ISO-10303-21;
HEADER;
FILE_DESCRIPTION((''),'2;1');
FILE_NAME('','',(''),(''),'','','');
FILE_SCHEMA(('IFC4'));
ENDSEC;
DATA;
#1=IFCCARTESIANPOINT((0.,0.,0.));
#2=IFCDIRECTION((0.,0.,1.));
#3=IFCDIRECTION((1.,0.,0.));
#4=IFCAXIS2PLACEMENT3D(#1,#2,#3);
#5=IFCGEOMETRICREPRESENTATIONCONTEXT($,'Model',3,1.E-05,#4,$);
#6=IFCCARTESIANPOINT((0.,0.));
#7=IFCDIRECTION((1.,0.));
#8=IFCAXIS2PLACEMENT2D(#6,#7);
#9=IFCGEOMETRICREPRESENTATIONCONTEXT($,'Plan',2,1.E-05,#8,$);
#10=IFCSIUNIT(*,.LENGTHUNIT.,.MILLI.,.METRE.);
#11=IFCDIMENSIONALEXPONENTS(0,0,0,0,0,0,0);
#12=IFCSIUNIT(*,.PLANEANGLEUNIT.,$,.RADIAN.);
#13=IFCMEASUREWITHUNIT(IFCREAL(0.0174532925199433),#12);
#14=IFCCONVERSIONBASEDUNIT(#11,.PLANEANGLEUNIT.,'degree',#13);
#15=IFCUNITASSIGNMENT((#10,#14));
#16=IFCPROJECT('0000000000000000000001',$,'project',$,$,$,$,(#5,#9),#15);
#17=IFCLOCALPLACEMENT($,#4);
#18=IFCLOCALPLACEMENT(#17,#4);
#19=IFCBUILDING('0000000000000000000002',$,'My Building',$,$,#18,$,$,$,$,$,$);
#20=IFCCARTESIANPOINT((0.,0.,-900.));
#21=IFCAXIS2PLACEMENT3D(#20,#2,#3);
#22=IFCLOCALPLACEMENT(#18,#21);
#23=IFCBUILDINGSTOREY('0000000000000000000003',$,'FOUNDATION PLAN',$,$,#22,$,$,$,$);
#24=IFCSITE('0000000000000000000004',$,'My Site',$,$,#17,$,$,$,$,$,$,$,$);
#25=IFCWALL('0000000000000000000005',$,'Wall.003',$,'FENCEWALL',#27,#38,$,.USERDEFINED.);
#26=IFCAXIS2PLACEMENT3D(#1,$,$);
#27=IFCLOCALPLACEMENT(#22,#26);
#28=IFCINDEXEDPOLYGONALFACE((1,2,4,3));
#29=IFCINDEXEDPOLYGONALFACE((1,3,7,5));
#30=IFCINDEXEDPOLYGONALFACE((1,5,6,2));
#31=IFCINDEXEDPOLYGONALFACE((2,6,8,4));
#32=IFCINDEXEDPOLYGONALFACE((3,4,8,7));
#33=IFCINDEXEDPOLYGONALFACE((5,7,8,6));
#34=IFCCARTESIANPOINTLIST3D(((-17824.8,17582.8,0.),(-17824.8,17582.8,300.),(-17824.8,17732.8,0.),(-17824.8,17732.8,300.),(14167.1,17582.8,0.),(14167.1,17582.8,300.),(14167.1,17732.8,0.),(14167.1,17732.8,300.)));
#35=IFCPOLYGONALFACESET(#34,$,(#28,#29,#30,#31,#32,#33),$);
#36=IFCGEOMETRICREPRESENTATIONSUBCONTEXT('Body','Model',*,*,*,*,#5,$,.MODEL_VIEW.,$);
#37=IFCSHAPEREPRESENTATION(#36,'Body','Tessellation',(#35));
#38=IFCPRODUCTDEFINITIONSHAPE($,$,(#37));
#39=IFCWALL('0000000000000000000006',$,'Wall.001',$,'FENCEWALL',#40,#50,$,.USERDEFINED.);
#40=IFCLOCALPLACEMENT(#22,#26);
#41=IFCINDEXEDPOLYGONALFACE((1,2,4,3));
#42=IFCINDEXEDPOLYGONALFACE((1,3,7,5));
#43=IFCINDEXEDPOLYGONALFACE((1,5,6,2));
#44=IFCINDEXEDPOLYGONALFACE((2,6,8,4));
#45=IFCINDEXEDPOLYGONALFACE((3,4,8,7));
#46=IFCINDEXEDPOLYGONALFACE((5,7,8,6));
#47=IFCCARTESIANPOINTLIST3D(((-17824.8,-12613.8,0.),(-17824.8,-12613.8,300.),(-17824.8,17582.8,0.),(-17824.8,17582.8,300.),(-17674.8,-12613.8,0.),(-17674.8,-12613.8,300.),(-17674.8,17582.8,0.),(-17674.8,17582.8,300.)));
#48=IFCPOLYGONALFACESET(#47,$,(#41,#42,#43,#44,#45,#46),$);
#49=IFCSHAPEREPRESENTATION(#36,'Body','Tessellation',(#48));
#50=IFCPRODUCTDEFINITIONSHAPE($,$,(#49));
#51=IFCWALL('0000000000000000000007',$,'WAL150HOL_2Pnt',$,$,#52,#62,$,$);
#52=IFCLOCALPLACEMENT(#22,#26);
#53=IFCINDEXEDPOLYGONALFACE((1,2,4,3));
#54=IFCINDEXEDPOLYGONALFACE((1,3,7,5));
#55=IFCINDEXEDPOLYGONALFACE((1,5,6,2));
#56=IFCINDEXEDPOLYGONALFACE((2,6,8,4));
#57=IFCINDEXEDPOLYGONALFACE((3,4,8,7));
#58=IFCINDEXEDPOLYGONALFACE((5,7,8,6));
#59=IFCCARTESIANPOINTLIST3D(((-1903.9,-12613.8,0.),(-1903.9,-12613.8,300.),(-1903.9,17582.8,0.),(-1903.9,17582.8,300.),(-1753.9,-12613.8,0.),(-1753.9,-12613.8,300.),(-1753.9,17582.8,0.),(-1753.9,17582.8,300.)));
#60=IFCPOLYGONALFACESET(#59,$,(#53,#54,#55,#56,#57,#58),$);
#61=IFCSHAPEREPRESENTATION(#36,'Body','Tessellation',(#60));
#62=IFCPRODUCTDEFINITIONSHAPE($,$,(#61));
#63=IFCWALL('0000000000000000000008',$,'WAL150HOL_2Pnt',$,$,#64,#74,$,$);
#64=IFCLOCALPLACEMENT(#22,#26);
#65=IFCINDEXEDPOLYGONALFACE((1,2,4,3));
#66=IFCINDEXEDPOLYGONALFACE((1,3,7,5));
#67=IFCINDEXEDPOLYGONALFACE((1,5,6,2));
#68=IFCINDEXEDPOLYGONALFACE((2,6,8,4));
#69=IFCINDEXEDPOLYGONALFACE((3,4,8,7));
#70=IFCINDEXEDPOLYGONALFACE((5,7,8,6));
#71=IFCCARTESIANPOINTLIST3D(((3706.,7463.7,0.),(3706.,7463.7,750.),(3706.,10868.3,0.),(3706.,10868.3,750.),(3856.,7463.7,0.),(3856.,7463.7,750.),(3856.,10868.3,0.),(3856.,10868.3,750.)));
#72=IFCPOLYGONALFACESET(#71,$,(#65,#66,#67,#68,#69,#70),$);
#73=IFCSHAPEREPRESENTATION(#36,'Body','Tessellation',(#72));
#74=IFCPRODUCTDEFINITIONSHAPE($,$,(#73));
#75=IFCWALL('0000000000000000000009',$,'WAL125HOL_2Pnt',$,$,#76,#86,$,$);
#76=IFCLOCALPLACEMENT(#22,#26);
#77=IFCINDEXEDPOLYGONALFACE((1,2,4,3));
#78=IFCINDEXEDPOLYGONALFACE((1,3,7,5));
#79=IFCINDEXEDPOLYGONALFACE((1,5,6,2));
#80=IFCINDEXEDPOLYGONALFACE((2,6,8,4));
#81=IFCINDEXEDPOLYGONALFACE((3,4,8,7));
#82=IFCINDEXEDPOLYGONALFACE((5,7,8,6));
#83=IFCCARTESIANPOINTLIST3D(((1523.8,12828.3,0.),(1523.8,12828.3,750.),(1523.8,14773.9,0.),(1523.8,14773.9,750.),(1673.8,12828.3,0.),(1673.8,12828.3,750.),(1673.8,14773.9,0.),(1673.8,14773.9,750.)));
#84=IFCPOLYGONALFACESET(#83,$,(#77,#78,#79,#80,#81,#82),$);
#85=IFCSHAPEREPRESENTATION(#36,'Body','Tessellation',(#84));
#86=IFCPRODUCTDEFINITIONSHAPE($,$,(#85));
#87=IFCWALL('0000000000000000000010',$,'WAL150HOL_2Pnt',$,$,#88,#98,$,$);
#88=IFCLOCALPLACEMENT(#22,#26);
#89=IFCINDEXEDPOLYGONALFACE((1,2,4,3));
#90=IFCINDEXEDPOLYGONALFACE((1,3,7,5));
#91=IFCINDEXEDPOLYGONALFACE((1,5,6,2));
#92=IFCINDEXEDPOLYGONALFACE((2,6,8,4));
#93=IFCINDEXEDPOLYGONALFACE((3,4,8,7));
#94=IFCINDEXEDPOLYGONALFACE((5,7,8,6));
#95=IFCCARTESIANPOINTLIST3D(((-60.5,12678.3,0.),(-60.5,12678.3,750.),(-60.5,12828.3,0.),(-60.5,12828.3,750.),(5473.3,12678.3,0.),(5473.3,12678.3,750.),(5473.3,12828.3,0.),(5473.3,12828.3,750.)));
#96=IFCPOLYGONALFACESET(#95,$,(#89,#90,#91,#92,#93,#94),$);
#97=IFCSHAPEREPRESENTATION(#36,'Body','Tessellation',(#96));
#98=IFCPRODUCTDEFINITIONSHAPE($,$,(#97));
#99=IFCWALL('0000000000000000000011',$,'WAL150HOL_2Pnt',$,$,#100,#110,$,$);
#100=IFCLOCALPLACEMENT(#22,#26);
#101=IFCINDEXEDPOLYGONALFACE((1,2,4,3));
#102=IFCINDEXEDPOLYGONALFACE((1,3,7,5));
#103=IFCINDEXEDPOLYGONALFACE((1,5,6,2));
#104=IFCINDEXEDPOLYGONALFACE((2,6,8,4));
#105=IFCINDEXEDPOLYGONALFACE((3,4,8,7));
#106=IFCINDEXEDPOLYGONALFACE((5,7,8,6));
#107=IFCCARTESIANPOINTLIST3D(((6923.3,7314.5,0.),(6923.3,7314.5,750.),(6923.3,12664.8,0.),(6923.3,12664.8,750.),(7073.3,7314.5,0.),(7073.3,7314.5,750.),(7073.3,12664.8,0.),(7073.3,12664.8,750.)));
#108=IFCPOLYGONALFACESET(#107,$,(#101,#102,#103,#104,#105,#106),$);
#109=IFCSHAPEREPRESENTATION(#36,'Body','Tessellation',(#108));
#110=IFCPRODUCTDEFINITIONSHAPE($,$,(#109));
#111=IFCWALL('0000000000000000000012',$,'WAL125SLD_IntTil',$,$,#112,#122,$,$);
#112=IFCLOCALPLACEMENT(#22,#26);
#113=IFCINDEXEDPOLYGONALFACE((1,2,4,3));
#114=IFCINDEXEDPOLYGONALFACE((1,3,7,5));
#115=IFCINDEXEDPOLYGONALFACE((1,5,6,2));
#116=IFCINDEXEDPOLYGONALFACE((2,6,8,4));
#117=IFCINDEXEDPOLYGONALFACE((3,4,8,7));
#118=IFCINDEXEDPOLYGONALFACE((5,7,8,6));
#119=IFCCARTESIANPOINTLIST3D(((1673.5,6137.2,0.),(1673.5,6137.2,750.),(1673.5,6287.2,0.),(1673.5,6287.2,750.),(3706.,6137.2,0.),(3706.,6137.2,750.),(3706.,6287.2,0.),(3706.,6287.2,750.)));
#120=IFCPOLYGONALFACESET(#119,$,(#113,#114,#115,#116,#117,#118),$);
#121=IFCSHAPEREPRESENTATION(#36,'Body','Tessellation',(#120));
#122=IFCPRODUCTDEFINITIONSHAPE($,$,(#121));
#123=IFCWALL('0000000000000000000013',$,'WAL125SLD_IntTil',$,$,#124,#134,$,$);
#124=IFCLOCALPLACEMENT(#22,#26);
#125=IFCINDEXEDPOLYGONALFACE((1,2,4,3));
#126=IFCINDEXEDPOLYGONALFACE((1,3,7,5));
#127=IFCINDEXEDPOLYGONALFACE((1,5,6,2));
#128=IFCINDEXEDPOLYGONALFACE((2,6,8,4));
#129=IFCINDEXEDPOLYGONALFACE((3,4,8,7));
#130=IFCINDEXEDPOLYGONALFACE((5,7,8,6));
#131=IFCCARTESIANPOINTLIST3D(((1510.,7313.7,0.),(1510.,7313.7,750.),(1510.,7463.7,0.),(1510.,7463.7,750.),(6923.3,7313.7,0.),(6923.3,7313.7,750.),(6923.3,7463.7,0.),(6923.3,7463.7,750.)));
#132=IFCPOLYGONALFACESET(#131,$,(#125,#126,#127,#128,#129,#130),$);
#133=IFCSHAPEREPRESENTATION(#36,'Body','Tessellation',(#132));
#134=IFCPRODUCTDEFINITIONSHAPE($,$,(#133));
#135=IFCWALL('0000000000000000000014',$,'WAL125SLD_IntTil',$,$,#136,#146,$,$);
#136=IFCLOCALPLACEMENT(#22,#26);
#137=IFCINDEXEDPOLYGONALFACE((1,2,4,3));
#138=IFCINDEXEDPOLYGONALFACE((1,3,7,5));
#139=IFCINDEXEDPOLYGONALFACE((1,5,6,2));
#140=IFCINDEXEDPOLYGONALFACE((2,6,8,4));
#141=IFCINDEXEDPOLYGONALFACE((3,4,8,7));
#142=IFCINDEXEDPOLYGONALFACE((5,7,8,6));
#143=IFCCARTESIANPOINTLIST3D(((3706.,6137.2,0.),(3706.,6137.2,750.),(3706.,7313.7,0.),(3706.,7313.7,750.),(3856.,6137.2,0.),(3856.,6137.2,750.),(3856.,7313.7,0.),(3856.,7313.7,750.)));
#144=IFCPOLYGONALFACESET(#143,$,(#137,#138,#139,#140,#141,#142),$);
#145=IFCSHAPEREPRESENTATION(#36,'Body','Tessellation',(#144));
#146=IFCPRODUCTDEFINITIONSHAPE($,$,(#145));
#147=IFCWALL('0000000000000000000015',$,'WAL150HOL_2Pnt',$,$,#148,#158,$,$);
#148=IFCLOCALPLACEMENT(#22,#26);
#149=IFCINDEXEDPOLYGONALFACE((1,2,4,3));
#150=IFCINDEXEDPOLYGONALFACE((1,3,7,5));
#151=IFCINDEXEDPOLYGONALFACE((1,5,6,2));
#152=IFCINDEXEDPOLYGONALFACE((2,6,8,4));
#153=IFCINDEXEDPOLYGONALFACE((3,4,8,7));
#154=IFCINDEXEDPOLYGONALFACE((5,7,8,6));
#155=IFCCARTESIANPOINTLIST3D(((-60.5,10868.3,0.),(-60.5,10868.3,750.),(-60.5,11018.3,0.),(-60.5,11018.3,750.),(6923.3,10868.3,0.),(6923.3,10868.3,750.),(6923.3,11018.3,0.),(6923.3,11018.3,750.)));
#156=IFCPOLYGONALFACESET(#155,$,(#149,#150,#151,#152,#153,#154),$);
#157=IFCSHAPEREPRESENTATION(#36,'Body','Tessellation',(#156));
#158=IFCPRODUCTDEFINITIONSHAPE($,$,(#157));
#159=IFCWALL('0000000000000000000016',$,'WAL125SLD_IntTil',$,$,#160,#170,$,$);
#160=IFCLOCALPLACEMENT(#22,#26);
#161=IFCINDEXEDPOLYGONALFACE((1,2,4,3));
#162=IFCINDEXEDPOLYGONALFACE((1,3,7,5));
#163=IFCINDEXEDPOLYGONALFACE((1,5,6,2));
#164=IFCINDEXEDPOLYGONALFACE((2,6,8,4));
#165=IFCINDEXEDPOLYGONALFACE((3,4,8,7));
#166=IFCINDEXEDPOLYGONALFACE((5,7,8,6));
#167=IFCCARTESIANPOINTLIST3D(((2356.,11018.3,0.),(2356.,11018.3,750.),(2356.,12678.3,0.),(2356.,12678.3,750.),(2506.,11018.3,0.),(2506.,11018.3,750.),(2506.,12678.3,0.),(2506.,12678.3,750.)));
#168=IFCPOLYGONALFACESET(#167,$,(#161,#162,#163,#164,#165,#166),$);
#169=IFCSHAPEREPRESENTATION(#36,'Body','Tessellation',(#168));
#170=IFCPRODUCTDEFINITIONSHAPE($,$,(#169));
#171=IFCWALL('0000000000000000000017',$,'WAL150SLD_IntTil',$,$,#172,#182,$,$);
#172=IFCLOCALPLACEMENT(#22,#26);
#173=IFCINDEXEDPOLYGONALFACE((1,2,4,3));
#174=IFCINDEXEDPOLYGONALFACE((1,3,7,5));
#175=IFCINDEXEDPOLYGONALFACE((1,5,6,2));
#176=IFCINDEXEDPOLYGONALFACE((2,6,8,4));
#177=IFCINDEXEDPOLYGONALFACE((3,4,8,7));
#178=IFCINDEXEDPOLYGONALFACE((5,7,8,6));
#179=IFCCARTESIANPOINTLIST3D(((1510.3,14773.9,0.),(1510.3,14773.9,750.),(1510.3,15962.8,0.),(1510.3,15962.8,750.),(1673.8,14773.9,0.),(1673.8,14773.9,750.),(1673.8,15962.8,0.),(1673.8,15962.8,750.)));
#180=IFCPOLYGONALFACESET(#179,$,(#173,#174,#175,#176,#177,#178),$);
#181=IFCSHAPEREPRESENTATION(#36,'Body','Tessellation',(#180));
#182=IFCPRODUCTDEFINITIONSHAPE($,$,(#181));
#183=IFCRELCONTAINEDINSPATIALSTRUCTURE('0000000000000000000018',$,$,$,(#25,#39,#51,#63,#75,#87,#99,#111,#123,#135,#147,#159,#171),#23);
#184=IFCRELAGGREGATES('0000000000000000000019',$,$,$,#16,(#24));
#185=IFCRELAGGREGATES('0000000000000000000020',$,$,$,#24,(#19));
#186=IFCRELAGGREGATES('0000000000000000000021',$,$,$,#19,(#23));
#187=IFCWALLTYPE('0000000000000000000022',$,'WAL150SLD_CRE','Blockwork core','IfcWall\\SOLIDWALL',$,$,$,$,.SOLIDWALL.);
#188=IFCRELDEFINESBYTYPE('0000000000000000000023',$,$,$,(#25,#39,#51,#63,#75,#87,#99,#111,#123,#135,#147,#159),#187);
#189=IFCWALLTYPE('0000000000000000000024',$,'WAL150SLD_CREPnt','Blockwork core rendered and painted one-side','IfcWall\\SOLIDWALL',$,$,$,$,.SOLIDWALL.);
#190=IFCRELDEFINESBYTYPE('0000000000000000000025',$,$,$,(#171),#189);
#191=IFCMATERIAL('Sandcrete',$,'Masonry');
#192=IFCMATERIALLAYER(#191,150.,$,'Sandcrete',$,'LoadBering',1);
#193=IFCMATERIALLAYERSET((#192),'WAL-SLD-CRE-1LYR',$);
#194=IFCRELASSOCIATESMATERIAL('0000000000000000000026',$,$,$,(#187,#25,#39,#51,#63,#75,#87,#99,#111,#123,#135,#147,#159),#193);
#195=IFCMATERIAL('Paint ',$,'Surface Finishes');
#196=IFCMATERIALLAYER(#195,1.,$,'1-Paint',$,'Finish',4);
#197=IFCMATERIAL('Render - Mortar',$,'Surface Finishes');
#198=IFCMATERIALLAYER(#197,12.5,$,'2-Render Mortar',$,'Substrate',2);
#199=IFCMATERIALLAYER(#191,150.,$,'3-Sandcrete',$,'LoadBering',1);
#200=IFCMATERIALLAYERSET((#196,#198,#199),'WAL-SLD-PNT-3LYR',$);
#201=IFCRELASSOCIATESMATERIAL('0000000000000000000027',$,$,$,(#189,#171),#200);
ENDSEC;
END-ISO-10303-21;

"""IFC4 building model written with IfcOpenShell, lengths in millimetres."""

from ifc_helpers import new_model, entity, si_unit, converted_unit, frame, origin_with_axes, origin_2d_with_axis, place, context, subcontext, project, spatial, indexed_curve, outline, extrude, material, layer, layer_set, layer_usage, type_object, element, save


model = new_model("IFC4")

# Units and contexts
model_context = context("Model", 3, precision=1e-05, world=origin_with_axes())
plan_context = context("Plan", 2, precision=1e-05, world=origin_2d_with_axis())
body_context = subcontext(model_context, "Body", "Model", "MODEL_VIEW")
ifc_project = project(units=[si_unit("LENGTHUNIT", "METRE", prefix="MILLI"), converted_unit("PLANEANGLEUNIT", "degree", entity("IfcReal", 0.0174532925199433), si_unit("PLANEANGLEUNIT", "RADIAN"), dimensions=[0, 0, 0, 0, 0, 0, 0])], contexts=[model_context, plan_context])

# Site, building, storey
site_placement = place(None, origin_with_axes())
site = spatial("IfcSite", under=ifc_project, at=site_placement, Name="My Site")
building_placement = place(site_placement, origin_with_axes())
building = spatial("IfcBuilding", under=site, at=building_placement, Name="My Building")
storey_placement = place(building_placement, frame((0.0, 0.0, -900.0), z_axis=(0.0, 0.0, 1.0), x_axis=(1.0, 0.0, 0.0)))
storey = spatial("IfcBuildingStorey", under=building, at=storey_placement, Name="FOUNDATION PLAN")

# Walls
ifc_material_1 = material(Name="Sandcrete", Category="Masonry")
ifc_layer_1 = layer(ifc_material_1, 150.0, Name="Sandcrete", Category="LoadBering", Priority=1)
ifc_layer_set_1 = layer_set([ifc_layer_1], Name="WAL-SLD-CRE-1LYR")
ifc_layer_usage_1 = layer_usage(ifc_layer_set_1, "AXIS2", "POSITIVE", 0.0)
wall_type_1 = type_object("IfcWallType", Name="WAL150SLD_CRE", Description="Blockwork core", ApplicableOccurrence="IfcWall\\SOLIDWALL", PredefinedType="SOLIDWALL", material=ifc_layer_set_1)
wall_1_placement = place(storey_placement, frame((-17824.8, 17582.8, 0.0), z_axis=(0.0, 0.0, 1.0), x_axis=(1.0, 0.0, 0.0)))
element("IfcWall", 1, at=wall_1_placement, inside=storey, type_object=wall_type_1, material=ifc_layer_usage_1, Name="Wall.003", ObjectType="FENCEWALL", PredefinedType="USERDEFINED", context=body_context, shape_type="SweptSolid", body=[
    extrude(outline(indexed_curve([(0.0, 0.0), (0.0, 150.0), (31991.9, 150.0), (31991.9, 0.0), (0.0, 0.0)], self_intersect=False)), origin_with_axes(), (0.0, 0.0, 1.0), 300.0),
])
ifc_layer_usage_2 = layer_usage(ifc_layer_set_1, "AXIS2", "POSITIVE", 0.0)
wall_2_placement = place(storey_placement, frame((-17824.8, 17582.8, 0.0), z_axis=(0.0, 0.0, 1.0), x_axis=(-0.000001, -1.0, 0.0)))
element("IfcWall", 2, at=wall_2_placement, inside=storey, type_object=wall_type_1, material=ifc_layer_usage_2, Name="Wall.001", ObjectType="FENCEWALL", PredefinedType="USERDEFINED", context=body_context, shape_type="SweptSolid", body=[
    extrude(outline(indexed_curve([(0.0, 0.0), (0.0, 150.0), (30196.6, 150.0), (30196.6, 0.0), (0.0, 0.0)], self_intersect=False)), origin_with_axes(), (0.0, 0.0, 1.0), 300.0),
])
ifc_layer_usage_3 = layer_usage(ifc_layer_set_1, "AXIS2", "POSITIVE", 0.0)
wall_3_placement = place(storey_placement, frame((-1903.9, 17582.8, 0.0), z_axis=(0.0, 0.0, 1.0), x_axis=(-0.000001, -1.0, 0.0)))
element("IfcWall", 3, at=wall_3_placement, inside=storey, type_object=wall_type_1, material=ifc_layer_usage_3, Name="WAL150HOL_2Pnt", context=body_context, shape_type="SweptSolid", body=[
    extrude(outline(indexed_curve([(0.0, 0.0), (0.0, 150.0), (30196.6, 150.0), (30196.6, 0.0), (0.0, 0.0)], self_intersect=False)), origin_with_axes(), (0.0, 0.0, 1.0), 300.0),
])
ifc_layer_usage_4 = layer_usage(ifc_layer_set_1, "AXIS2", "POSITIVE", 0.0)
wall_4_placement = place(storey_placement, frame((3856.0, 7463.7, 0.0), z_axis=(0.0, 0.0, 1.0), x_axis=(0.0, 1.0, 0.0)))
element("IfcWall", 4, at=wall_4_placement, inside=storey, type_object=wall_type_1, material=ifc_layer_usage_4, Name="WAL150HOL_2Pnt", context=body_context, shape_type="SweptSolid", body=[
    extrude(outline(indexed_curve([(0.0, 0.0), (0.0, 150.0), (3404.6, 150.0), (3404.6, 0.0), (0.0, 0.0)], self_intersect=False)), origin_with_axes(), (0.0, 0.0, 1.0), 750.0),
])
ifc_layer_usage_5 = layer_usage(ifc_layer_set_1, "AXIS2", "POSITIVE", 0.0)
wall_5_placement = place(storey_placement, frame((1523.8, 14773.9, 0.0), z_axis=(0.0, 0.0, 1.0), x_axis=(-0.000001, -1.0, 0.0)))
element("IfcWall", 5, at=wall_5_placement, inside=storey, type_object=wall_type_1, material=ifc_layer_usage_5, Name="WAL125HOL_2Pnt", context=body_context, shape_type="SweptSolid", body=[
    extrude(outline(indexed_curve([(0.0, 0.0), (0.0, 150.0), (1945.6, 150.0), (1945.6, 0.0), (0.0, 0.0)], self_intersect=False)), origin_with_axes(), (0.0, 0.0, 1.0), 750.0),
])
ifc_layer_usage_6 = layer_usage(ifc_layer_set_1, "AXIS2", "POSITIVE", 0.0)
wall_6_placement = place(storey_placement, frame((5473.3, 12828.3, 0.0), z_axis=(0.0, 0.0, 1.0), x_axis=(-1.0, 0.0, 0.0)))
element("IfcWall", 6, at=wall_6_placement, inside=storey, type_object=wall_type_1, material=ifc_layer_usage_6, Name="WAL150HOL_2Pnt", context=body_context, shape_type="SweptSolid", body=[
    extrude(outline(indexed_curve([(0.0, 0.0), (0.0, 150.0), (5533.8, 150.0), (5533.8, 0.0), (0.0, 0.0)], self_intersect=False)), origin_with_axes(), (0.0, 0.0, 1.0), 750.0),
])
ifc_layer_usage_7 = layer_usage(ifc_layer_set_1, "AXIS2", "POSITIVE", 0.0)
wall_7_placement = place(storey_placement, frame((6923.3, 12664.8, 0.0), z_axis=(0.0, 0.0, 1.0), x_axis=(-0.000001, -1.0, 0.0)))
element("IfcWall", 7, at=wall_7_placement, inside=storey, type_object=wall_type_1, material=ifc_layer_usage_7, Name="WAL150HOL_2Pnt", context=body_context, shape_type="SweptSolid", body=[
    extrude(outline(indexed_curve([(0.0, 0.0), (0.0, 150.0), (5350.3, 150.0), (5350.3, 0.0), (0.0, 0.0)], self_intersect=False)), origin_with_axes(), (0.0, 0.0, 1.0), 750.0),
])
ifc_layer_usage_8 = layer_usage(ifc_layer_set_1, "AXIS2", "POSITIVE", 0.0)
wall_8_placement = place(storey_placement, frame((1673.5, 6137.2, 0.0), z_axis=(0.0, 0.0, 1.0), x_axis=(1.0, 0.0, 0.0)))
element("IfcWall", 8, at=wall_8_placement, inside=storey, type_object=wall_type_1, material=ifc_layer_usage_8, Name="WAL125SLD_IntTil", context=body_context, shape_type="SweptSolid", body=[
    extrude(outline(indexed_curve([(0.0, 0.0), (0.0, 150.0), (2032.5, 150.0), (2032.5, 0.0), (0.0, 0.0)], self_intersect=False)), origin_with_axes(), (0.0, 0.0, 1.0), 750.0),
])
ifc_layer_usage_9 = layer_usage(ifc_layer_set_1, "AXIS2", "POSITIVE", 0.0)
wall_9_placement = place(storey_placement, frame((6923.3, 7463.7, 0.0), z_axis=(0.0, 0.0, 1.0), x_axis=(-1.0, 0.0, 0.0)))
element("IfcWall", 9, at=wall_9_placement, inside=storey, type_object=wall_type_1, material=ifc_layer_usage_9, Name="WAL125SLD_IntTil", context=body_context, shape_type="SweptSolid", body=[
    extrude(outline(indexed_curve([(0.0, 0.0), (0.0, 150.0), (5413.3, 150.0), (5413.3, 0.0), (0.0, 0.0)], self_intersect=False)), origin_with_axes(), (0.0, 0.0, 1.0), 750.0),
])
ifc_layer_usage_10 = layer_usage(ifc_layer_set_1, "AXIS2", "POSITIVE", 0.0)
wall_10_placement = place(storey_placement, frame((3856.0, 6137.2, 0.0), z_axis=(0.0, 0.0, 1.0), x_axis=(0.0, 1.0, 0.0)))
element("IfcWall", 10, at=wall_10_placement, inside=storey, type_object=wall_type_1, material=ifc_layer_usage_10, Name="WAL125SLD_IntTil", context=body_context, shape_type="SweptSolid", body=[
    extrude(outline(indexed_curve([(0.0, 0.0), (0.0, 150.0), (1176.5, 150.0), (1176.5, 0.0), (0.0, 0.0)], self_intersect=False)), origin_with_axes(), (0.0, 0.0, 1.0), 750.0),
])
ifc_layer_usage_11 = layer_usage(ifc_layer_set_1, "AXIS2", "POSITIVE", 0.0)
wall_11_placement = place(storey_placement, frame((-60.5, 10868.3, 0.0), z_axis=(0.0, 0.0, 1.0), x_axis=(1.0, -0.000002, 0.0)))
element("IfcWall", 11, at=wall_11_placement, inside=storey, type_object=wall_type_1, material=ifc_layer_usage_11, Name="WAL150HOL_2Pnt", context=body_context, shape_type="SweptSolid", body=[
    extrude(outline(indexed_curve([(0.0, 0.0), (0.0, 150.0), (6983.8, 150.0), (6983.8, 0.0), (0.0, 0.0)], self_intersect=False)), origin_with_axes(), (0.0, 0.0, 1.0), 750.0),
])
ifc_layer_usage_12 = layer_usage(ifc_layer_set_1, "AXIS2", "POSITIVE", 0.0)
wall_12_placement = place(storey_placement, frame((2506.0, 11018.3, 0.0), z_axis=(0.0, 0.0, 1.0), x_axis=(0.0, 1.0, 0.0)))
element("IfcWall", 12, at=wall_12_placement, inside=storey, type_object=wall_type_1, material=ifc_layer_usage_12, Name="WAL125SLD_IntTil", context=body_context, shape_type="SweptSolid", body=[
    extrude(outline(indexed_curve([(0.0, 0.0), (0.0, 150.0), (1660.0, 150.0), (1660.0, 0.0), (0.0, 0.0)], self_intersect=False)), origin_with_axes(), (0.0, 0.0, 1.0), 750.0),
])
ifc_material_2 = material(Name="Paint ", Category="Surface Finishes")
ifc_layer_2 = layer(ifc_material_2, 1.0, Name="1-Paint", Category="Finish", Priority=4)
ifc_material_3 = material(Name="Render - Mortar", Category="Surface Finishes")
ifc_layer_3 = layer(ifc_material_3, 12.5, Name="2-Render Mortar", Category="Substrate", Priority=2)
ifc_layer_4 = layer(ifc_material_1, 150.0, Name="3-Sandcrete", Category="LoadBering", Priority=1)
ifc_layer_set_2 = layer_set([ifc_layer_2, ifc_layer_3, ifc_layer_4], Name="WAL-SLD-PNT-3LYR")
ifc_layer_usage_13 = layer_usage(ifc_layer_set_2, "AXIS2", "POSITIVE", 0.0)
wall_type_2 = type_object("IfcWallType", Name="WAL150SLD_CREPnt", Description="Blockwork core rendered and painted one-side", ApplicableOccurrence="IfcWall\\SOLIDWALL", PredefinedType="SOLIDWALL", material=ifc_layer_set_2)
wall_13_placement = place(storey_placement, frame((1510.3, 15962.8, 0.0), z_axis=(0.0, 0.0, 1.0), x_axis=(-0.000001, -1.0, 0.0)))
element("IfcWall", 13, at=wall_13_placement, inside=storey, type_object=wall_type_2, material=ifc_layer_usage_13, Name="WAL150SLD_IntTil", context=body_context, shape_type="SweptSolid", body=[
    extrude(outline(indexed_curve([(0.0, 0.0), (0.0, 163.5), (1188.9, 163.5), (1188.9, 0.0), (0.0, 0.0)], self_intersect=False)), origin_with_axes(), (0.0, 0.0, 1.0), 750.0),
])

save(model, "model.ifc")
